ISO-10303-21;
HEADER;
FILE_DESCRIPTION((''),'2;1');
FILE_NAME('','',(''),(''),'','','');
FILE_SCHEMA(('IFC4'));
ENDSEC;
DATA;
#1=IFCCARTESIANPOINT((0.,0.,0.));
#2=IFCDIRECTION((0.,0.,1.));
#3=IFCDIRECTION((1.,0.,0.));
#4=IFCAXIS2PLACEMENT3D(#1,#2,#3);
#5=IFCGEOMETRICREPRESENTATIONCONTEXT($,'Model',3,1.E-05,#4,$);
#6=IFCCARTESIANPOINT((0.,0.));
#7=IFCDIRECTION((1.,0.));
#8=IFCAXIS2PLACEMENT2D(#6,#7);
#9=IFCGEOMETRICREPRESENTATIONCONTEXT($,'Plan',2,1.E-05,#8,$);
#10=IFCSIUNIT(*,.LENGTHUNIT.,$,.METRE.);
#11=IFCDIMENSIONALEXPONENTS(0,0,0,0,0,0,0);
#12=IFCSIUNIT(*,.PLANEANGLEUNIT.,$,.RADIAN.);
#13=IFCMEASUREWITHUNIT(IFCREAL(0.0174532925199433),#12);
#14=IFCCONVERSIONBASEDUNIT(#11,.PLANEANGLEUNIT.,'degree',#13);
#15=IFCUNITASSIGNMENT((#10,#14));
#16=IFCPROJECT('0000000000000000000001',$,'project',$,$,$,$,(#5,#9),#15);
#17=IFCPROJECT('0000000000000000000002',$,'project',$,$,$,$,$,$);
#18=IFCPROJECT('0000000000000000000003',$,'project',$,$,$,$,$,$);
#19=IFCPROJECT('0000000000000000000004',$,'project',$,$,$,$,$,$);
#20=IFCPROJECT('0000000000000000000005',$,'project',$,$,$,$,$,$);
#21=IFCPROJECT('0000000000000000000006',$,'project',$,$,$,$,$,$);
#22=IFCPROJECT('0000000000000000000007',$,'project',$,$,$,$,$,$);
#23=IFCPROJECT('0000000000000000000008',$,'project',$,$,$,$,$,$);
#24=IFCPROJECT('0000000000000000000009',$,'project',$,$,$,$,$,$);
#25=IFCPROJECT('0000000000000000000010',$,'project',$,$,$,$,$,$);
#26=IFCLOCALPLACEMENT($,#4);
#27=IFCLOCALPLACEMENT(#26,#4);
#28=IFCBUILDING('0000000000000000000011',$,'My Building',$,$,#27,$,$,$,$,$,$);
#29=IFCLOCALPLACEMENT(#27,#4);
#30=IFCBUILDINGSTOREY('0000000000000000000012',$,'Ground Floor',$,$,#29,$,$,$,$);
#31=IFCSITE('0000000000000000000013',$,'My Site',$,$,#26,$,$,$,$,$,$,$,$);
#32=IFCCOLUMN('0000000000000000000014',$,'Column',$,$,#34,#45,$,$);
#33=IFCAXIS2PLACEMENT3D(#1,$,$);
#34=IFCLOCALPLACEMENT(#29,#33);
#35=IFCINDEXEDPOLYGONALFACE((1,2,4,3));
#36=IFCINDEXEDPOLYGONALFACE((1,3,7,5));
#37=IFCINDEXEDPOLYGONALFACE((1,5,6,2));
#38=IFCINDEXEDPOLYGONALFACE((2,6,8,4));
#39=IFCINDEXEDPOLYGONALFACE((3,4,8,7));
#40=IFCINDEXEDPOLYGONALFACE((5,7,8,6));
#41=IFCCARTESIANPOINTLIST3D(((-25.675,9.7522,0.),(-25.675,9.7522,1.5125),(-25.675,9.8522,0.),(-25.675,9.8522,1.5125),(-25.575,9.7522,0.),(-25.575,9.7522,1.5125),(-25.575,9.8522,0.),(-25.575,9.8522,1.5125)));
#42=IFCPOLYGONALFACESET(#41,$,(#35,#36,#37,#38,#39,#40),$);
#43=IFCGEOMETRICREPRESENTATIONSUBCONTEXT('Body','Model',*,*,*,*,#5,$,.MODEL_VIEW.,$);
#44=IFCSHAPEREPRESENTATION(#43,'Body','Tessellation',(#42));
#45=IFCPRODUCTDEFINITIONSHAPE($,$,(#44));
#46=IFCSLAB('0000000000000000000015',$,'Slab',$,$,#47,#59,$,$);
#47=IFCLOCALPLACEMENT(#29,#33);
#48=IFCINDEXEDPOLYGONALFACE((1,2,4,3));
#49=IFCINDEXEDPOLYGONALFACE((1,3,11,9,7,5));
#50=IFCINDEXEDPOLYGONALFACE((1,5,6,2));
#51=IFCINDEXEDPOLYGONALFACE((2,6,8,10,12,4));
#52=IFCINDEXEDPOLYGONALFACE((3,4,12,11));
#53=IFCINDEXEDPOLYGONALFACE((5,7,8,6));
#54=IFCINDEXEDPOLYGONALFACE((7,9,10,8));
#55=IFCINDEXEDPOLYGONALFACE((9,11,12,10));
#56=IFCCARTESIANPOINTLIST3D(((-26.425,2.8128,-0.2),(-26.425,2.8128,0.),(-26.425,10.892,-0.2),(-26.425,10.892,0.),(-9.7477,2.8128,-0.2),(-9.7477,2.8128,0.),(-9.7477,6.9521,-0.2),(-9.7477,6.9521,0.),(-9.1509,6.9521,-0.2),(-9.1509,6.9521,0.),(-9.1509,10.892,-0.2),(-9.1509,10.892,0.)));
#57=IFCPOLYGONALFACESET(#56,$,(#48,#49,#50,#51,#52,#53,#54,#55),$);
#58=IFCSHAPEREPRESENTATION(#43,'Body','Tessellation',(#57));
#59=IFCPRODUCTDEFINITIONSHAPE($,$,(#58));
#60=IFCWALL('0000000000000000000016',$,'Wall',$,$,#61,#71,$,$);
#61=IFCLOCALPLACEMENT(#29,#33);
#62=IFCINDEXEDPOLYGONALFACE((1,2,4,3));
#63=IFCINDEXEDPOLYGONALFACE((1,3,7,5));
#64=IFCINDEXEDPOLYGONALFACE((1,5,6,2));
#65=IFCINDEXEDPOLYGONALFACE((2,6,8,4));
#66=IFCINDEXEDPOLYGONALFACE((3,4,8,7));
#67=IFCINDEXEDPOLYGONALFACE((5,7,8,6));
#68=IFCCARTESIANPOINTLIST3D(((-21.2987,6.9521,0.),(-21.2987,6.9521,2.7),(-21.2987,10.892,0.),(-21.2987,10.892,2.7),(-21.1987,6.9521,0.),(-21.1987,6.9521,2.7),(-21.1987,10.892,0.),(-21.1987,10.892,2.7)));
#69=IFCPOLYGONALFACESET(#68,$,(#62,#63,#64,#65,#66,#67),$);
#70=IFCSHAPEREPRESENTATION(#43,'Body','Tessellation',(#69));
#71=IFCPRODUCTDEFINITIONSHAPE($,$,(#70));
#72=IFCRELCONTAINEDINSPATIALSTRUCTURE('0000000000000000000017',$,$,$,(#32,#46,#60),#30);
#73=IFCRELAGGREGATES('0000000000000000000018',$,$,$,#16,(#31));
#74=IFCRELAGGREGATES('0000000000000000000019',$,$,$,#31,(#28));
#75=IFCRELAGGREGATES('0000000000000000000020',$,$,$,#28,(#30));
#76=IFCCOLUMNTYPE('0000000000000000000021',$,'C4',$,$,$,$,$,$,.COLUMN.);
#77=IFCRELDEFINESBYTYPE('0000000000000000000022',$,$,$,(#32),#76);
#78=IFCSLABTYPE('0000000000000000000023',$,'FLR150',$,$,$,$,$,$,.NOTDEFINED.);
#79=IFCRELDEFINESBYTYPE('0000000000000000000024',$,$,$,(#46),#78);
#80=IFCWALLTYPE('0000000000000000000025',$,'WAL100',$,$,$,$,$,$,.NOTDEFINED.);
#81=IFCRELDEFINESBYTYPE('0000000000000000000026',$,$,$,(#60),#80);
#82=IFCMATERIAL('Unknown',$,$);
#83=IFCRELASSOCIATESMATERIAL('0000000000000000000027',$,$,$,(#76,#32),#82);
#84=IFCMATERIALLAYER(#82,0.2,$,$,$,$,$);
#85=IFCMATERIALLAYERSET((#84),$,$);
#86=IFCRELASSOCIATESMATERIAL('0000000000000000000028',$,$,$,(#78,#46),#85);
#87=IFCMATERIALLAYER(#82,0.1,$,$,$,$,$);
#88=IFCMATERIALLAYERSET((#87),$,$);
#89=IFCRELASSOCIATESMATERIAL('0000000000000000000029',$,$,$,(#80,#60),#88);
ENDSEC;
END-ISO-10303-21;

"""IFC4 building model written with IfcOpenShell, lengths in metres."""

from ifc_helpers import new_model, entity, si_unit, converted_unit, frame, origin_with_axes, origin_2d_with_axis, place, context, subcontext, project, spatial, line, indexed_curve, rectangle, outline, extrude, material, layer, layer_set, layer_usage, material_profile, profile_set, profile_usage, type_object, element, save


model = new_model("IFC4")

# Units and contexts
model_context = context("Model", 3, precision=1e-05, world=origin_with_axes())
plan_context = context("Plan", 2, precision=1e-05, world=origin_2d_with_axis())
body_context_1 = subcontext(model_context, "Body", "Model", "MODEL_VIEW")
ifc_project_1 = project(units=[si_unit("LENGTHUNIT", "METRE"), converted_unit("PLANEANGLEUNIT", "degree", entity("IfcReal", 0.0174532925199433), si_unit("PLANEANGLEUNIT", "RADIAN"), dimensions=[0, 0, 0, 0, 0, 0, 0])], contexts=[model_context, plan_context])
ifc_project_2 = project()
ifc_project_3 = project()
ifc_project_4 = project()
ifc_project_5 = project()
ifc_project_6 = project()
ifc_project_7 = project()
ifc_project_8 = project()
ifc_project_9 = project()
ifc_project_10 = project()

# Site, building, storey
site_placement = place(None, origin_with_axes())
site = spatial("IfcSite", under=ifc_project_1, at=site_placement, Name="My Site")
building_placement = place(site_placement, origin_with_axes())
building = spatial("IfcBuilding", under=site, at=building_placement, Name="My Building")
storey_placement = place(building_placement, origin_with_axes())
storey = spatial("IfcBuildingStorey", under=building, at=storey_placement, Name="Ground Floor")

# Column
ifc_material = material(Name="Unknown")
ifc_material_profile = material_profile(ifc_material, rectangle(XDim=0.1, YDim=0.1))
ifc_profile_set = profile_set([ifc_material_profile])
ifc_profile_usage = profile_usage(ifc_profile_set, cardinal=5)
column_type = type_object("IfcColumnType", Name="C4", PredefinedType="COLUMN", material=ifc_profile_set)
column_placement = place(storey_placement, frame((-25.625, 9.8022, 0.0), z_axis=(0.0, 0.0, 1.0), x_axis=(1.0, 0.0, 0.0)))
element("IfcColumn", 1, at=column_placement, inside=storey, type_object=column_type, material=ifc_profile_usage, Name="Column", context=body_context_1, shape_type="SweptSolid", body=[
    extrude(rectangle(XDim=0.1, YDim=0.1), origin_with_axes(), (0.0, 0.0, 1.0), 1.5125),
])

# Slab
ifc_layer_1 = layer(ifc_material, 0.2)
ifc_layer_set_1 = layer_set([ifc_layer_1])
ifc_layer_usage_1 = layer_usage(ifc_layer_set_1, "AXIS3", "POSITIVE", 0.0)
slab_type = type_object("IfcSlabType", Name="FLR150", PredefinedType="NOTDEFINED", material=ifc_layer_set_1)
slab_1_placement = place(storey_placement, frame((-26.425, 2.8128, -0.2), z_axis=(0.0, 0.0, 1.0), x_axis=(1.0, 0.0, 0.0)))
element("IfcSlab", 2, at=slab_1_placement, inside=storey, type_object=slab_type, material=ifc_layer_usage_1, Name="Slab", context=body_context_1, shape_type="SweptSolid", body=[
    extrude(outline(indexed_curve([(17.2741, 4.1393), (17.2741, 8.0792), (0.0, 8.0792), (0.0, 0.0), (16.6773, 0.0), (16.6773, 4.1393)], segments=[line(6, 5), line(5, 4), line(4, 3), line(3, 2), line(2, 1), line(1, 6)], self_intersect=False)), None, (0.0, 0.0, 1.0), 0.2),
])

# Wall
ifc_layer_2 = layer(ifc_material, 0.1)
ifc_layer_set_2 = layer_set([ifc_layer_2])
ifc_layer_usage_2 = layer_usage(ifc_layer_set_2, "AXIS2", "POSITIVE", 0.0)
wall_type = type_object("IfcWallType", Name="WAL100", PredefinedType="NOTDEFINED", material=ifc_layer_set_2)
wall_1_placement = place(storey_placement, frame((-21.2987, 10.892, 0.0), z_axis=(0.0, 0.0, 1.0), x_axis=(-0.000001, -1.0, 0.0)))
element("IfcWall", 3, at=wall_1_placement, inside=storey, type_object=wall_type, material=ifc_layer_usage_2, Name="Wall", context=body_context_1, shape_type="SweptSolid", body=[
    extrude(outline(indexed_curve([(0.0, 0.0), (0.0, 0.1), (3.9399, 0.1), (3.9399, 0.0), (0.0, 0.0)], self_intersect=False)), origin_with_axes(), (0.0, 0.0, 1.0), 2.7),
])

save(model, "model.ifc")
